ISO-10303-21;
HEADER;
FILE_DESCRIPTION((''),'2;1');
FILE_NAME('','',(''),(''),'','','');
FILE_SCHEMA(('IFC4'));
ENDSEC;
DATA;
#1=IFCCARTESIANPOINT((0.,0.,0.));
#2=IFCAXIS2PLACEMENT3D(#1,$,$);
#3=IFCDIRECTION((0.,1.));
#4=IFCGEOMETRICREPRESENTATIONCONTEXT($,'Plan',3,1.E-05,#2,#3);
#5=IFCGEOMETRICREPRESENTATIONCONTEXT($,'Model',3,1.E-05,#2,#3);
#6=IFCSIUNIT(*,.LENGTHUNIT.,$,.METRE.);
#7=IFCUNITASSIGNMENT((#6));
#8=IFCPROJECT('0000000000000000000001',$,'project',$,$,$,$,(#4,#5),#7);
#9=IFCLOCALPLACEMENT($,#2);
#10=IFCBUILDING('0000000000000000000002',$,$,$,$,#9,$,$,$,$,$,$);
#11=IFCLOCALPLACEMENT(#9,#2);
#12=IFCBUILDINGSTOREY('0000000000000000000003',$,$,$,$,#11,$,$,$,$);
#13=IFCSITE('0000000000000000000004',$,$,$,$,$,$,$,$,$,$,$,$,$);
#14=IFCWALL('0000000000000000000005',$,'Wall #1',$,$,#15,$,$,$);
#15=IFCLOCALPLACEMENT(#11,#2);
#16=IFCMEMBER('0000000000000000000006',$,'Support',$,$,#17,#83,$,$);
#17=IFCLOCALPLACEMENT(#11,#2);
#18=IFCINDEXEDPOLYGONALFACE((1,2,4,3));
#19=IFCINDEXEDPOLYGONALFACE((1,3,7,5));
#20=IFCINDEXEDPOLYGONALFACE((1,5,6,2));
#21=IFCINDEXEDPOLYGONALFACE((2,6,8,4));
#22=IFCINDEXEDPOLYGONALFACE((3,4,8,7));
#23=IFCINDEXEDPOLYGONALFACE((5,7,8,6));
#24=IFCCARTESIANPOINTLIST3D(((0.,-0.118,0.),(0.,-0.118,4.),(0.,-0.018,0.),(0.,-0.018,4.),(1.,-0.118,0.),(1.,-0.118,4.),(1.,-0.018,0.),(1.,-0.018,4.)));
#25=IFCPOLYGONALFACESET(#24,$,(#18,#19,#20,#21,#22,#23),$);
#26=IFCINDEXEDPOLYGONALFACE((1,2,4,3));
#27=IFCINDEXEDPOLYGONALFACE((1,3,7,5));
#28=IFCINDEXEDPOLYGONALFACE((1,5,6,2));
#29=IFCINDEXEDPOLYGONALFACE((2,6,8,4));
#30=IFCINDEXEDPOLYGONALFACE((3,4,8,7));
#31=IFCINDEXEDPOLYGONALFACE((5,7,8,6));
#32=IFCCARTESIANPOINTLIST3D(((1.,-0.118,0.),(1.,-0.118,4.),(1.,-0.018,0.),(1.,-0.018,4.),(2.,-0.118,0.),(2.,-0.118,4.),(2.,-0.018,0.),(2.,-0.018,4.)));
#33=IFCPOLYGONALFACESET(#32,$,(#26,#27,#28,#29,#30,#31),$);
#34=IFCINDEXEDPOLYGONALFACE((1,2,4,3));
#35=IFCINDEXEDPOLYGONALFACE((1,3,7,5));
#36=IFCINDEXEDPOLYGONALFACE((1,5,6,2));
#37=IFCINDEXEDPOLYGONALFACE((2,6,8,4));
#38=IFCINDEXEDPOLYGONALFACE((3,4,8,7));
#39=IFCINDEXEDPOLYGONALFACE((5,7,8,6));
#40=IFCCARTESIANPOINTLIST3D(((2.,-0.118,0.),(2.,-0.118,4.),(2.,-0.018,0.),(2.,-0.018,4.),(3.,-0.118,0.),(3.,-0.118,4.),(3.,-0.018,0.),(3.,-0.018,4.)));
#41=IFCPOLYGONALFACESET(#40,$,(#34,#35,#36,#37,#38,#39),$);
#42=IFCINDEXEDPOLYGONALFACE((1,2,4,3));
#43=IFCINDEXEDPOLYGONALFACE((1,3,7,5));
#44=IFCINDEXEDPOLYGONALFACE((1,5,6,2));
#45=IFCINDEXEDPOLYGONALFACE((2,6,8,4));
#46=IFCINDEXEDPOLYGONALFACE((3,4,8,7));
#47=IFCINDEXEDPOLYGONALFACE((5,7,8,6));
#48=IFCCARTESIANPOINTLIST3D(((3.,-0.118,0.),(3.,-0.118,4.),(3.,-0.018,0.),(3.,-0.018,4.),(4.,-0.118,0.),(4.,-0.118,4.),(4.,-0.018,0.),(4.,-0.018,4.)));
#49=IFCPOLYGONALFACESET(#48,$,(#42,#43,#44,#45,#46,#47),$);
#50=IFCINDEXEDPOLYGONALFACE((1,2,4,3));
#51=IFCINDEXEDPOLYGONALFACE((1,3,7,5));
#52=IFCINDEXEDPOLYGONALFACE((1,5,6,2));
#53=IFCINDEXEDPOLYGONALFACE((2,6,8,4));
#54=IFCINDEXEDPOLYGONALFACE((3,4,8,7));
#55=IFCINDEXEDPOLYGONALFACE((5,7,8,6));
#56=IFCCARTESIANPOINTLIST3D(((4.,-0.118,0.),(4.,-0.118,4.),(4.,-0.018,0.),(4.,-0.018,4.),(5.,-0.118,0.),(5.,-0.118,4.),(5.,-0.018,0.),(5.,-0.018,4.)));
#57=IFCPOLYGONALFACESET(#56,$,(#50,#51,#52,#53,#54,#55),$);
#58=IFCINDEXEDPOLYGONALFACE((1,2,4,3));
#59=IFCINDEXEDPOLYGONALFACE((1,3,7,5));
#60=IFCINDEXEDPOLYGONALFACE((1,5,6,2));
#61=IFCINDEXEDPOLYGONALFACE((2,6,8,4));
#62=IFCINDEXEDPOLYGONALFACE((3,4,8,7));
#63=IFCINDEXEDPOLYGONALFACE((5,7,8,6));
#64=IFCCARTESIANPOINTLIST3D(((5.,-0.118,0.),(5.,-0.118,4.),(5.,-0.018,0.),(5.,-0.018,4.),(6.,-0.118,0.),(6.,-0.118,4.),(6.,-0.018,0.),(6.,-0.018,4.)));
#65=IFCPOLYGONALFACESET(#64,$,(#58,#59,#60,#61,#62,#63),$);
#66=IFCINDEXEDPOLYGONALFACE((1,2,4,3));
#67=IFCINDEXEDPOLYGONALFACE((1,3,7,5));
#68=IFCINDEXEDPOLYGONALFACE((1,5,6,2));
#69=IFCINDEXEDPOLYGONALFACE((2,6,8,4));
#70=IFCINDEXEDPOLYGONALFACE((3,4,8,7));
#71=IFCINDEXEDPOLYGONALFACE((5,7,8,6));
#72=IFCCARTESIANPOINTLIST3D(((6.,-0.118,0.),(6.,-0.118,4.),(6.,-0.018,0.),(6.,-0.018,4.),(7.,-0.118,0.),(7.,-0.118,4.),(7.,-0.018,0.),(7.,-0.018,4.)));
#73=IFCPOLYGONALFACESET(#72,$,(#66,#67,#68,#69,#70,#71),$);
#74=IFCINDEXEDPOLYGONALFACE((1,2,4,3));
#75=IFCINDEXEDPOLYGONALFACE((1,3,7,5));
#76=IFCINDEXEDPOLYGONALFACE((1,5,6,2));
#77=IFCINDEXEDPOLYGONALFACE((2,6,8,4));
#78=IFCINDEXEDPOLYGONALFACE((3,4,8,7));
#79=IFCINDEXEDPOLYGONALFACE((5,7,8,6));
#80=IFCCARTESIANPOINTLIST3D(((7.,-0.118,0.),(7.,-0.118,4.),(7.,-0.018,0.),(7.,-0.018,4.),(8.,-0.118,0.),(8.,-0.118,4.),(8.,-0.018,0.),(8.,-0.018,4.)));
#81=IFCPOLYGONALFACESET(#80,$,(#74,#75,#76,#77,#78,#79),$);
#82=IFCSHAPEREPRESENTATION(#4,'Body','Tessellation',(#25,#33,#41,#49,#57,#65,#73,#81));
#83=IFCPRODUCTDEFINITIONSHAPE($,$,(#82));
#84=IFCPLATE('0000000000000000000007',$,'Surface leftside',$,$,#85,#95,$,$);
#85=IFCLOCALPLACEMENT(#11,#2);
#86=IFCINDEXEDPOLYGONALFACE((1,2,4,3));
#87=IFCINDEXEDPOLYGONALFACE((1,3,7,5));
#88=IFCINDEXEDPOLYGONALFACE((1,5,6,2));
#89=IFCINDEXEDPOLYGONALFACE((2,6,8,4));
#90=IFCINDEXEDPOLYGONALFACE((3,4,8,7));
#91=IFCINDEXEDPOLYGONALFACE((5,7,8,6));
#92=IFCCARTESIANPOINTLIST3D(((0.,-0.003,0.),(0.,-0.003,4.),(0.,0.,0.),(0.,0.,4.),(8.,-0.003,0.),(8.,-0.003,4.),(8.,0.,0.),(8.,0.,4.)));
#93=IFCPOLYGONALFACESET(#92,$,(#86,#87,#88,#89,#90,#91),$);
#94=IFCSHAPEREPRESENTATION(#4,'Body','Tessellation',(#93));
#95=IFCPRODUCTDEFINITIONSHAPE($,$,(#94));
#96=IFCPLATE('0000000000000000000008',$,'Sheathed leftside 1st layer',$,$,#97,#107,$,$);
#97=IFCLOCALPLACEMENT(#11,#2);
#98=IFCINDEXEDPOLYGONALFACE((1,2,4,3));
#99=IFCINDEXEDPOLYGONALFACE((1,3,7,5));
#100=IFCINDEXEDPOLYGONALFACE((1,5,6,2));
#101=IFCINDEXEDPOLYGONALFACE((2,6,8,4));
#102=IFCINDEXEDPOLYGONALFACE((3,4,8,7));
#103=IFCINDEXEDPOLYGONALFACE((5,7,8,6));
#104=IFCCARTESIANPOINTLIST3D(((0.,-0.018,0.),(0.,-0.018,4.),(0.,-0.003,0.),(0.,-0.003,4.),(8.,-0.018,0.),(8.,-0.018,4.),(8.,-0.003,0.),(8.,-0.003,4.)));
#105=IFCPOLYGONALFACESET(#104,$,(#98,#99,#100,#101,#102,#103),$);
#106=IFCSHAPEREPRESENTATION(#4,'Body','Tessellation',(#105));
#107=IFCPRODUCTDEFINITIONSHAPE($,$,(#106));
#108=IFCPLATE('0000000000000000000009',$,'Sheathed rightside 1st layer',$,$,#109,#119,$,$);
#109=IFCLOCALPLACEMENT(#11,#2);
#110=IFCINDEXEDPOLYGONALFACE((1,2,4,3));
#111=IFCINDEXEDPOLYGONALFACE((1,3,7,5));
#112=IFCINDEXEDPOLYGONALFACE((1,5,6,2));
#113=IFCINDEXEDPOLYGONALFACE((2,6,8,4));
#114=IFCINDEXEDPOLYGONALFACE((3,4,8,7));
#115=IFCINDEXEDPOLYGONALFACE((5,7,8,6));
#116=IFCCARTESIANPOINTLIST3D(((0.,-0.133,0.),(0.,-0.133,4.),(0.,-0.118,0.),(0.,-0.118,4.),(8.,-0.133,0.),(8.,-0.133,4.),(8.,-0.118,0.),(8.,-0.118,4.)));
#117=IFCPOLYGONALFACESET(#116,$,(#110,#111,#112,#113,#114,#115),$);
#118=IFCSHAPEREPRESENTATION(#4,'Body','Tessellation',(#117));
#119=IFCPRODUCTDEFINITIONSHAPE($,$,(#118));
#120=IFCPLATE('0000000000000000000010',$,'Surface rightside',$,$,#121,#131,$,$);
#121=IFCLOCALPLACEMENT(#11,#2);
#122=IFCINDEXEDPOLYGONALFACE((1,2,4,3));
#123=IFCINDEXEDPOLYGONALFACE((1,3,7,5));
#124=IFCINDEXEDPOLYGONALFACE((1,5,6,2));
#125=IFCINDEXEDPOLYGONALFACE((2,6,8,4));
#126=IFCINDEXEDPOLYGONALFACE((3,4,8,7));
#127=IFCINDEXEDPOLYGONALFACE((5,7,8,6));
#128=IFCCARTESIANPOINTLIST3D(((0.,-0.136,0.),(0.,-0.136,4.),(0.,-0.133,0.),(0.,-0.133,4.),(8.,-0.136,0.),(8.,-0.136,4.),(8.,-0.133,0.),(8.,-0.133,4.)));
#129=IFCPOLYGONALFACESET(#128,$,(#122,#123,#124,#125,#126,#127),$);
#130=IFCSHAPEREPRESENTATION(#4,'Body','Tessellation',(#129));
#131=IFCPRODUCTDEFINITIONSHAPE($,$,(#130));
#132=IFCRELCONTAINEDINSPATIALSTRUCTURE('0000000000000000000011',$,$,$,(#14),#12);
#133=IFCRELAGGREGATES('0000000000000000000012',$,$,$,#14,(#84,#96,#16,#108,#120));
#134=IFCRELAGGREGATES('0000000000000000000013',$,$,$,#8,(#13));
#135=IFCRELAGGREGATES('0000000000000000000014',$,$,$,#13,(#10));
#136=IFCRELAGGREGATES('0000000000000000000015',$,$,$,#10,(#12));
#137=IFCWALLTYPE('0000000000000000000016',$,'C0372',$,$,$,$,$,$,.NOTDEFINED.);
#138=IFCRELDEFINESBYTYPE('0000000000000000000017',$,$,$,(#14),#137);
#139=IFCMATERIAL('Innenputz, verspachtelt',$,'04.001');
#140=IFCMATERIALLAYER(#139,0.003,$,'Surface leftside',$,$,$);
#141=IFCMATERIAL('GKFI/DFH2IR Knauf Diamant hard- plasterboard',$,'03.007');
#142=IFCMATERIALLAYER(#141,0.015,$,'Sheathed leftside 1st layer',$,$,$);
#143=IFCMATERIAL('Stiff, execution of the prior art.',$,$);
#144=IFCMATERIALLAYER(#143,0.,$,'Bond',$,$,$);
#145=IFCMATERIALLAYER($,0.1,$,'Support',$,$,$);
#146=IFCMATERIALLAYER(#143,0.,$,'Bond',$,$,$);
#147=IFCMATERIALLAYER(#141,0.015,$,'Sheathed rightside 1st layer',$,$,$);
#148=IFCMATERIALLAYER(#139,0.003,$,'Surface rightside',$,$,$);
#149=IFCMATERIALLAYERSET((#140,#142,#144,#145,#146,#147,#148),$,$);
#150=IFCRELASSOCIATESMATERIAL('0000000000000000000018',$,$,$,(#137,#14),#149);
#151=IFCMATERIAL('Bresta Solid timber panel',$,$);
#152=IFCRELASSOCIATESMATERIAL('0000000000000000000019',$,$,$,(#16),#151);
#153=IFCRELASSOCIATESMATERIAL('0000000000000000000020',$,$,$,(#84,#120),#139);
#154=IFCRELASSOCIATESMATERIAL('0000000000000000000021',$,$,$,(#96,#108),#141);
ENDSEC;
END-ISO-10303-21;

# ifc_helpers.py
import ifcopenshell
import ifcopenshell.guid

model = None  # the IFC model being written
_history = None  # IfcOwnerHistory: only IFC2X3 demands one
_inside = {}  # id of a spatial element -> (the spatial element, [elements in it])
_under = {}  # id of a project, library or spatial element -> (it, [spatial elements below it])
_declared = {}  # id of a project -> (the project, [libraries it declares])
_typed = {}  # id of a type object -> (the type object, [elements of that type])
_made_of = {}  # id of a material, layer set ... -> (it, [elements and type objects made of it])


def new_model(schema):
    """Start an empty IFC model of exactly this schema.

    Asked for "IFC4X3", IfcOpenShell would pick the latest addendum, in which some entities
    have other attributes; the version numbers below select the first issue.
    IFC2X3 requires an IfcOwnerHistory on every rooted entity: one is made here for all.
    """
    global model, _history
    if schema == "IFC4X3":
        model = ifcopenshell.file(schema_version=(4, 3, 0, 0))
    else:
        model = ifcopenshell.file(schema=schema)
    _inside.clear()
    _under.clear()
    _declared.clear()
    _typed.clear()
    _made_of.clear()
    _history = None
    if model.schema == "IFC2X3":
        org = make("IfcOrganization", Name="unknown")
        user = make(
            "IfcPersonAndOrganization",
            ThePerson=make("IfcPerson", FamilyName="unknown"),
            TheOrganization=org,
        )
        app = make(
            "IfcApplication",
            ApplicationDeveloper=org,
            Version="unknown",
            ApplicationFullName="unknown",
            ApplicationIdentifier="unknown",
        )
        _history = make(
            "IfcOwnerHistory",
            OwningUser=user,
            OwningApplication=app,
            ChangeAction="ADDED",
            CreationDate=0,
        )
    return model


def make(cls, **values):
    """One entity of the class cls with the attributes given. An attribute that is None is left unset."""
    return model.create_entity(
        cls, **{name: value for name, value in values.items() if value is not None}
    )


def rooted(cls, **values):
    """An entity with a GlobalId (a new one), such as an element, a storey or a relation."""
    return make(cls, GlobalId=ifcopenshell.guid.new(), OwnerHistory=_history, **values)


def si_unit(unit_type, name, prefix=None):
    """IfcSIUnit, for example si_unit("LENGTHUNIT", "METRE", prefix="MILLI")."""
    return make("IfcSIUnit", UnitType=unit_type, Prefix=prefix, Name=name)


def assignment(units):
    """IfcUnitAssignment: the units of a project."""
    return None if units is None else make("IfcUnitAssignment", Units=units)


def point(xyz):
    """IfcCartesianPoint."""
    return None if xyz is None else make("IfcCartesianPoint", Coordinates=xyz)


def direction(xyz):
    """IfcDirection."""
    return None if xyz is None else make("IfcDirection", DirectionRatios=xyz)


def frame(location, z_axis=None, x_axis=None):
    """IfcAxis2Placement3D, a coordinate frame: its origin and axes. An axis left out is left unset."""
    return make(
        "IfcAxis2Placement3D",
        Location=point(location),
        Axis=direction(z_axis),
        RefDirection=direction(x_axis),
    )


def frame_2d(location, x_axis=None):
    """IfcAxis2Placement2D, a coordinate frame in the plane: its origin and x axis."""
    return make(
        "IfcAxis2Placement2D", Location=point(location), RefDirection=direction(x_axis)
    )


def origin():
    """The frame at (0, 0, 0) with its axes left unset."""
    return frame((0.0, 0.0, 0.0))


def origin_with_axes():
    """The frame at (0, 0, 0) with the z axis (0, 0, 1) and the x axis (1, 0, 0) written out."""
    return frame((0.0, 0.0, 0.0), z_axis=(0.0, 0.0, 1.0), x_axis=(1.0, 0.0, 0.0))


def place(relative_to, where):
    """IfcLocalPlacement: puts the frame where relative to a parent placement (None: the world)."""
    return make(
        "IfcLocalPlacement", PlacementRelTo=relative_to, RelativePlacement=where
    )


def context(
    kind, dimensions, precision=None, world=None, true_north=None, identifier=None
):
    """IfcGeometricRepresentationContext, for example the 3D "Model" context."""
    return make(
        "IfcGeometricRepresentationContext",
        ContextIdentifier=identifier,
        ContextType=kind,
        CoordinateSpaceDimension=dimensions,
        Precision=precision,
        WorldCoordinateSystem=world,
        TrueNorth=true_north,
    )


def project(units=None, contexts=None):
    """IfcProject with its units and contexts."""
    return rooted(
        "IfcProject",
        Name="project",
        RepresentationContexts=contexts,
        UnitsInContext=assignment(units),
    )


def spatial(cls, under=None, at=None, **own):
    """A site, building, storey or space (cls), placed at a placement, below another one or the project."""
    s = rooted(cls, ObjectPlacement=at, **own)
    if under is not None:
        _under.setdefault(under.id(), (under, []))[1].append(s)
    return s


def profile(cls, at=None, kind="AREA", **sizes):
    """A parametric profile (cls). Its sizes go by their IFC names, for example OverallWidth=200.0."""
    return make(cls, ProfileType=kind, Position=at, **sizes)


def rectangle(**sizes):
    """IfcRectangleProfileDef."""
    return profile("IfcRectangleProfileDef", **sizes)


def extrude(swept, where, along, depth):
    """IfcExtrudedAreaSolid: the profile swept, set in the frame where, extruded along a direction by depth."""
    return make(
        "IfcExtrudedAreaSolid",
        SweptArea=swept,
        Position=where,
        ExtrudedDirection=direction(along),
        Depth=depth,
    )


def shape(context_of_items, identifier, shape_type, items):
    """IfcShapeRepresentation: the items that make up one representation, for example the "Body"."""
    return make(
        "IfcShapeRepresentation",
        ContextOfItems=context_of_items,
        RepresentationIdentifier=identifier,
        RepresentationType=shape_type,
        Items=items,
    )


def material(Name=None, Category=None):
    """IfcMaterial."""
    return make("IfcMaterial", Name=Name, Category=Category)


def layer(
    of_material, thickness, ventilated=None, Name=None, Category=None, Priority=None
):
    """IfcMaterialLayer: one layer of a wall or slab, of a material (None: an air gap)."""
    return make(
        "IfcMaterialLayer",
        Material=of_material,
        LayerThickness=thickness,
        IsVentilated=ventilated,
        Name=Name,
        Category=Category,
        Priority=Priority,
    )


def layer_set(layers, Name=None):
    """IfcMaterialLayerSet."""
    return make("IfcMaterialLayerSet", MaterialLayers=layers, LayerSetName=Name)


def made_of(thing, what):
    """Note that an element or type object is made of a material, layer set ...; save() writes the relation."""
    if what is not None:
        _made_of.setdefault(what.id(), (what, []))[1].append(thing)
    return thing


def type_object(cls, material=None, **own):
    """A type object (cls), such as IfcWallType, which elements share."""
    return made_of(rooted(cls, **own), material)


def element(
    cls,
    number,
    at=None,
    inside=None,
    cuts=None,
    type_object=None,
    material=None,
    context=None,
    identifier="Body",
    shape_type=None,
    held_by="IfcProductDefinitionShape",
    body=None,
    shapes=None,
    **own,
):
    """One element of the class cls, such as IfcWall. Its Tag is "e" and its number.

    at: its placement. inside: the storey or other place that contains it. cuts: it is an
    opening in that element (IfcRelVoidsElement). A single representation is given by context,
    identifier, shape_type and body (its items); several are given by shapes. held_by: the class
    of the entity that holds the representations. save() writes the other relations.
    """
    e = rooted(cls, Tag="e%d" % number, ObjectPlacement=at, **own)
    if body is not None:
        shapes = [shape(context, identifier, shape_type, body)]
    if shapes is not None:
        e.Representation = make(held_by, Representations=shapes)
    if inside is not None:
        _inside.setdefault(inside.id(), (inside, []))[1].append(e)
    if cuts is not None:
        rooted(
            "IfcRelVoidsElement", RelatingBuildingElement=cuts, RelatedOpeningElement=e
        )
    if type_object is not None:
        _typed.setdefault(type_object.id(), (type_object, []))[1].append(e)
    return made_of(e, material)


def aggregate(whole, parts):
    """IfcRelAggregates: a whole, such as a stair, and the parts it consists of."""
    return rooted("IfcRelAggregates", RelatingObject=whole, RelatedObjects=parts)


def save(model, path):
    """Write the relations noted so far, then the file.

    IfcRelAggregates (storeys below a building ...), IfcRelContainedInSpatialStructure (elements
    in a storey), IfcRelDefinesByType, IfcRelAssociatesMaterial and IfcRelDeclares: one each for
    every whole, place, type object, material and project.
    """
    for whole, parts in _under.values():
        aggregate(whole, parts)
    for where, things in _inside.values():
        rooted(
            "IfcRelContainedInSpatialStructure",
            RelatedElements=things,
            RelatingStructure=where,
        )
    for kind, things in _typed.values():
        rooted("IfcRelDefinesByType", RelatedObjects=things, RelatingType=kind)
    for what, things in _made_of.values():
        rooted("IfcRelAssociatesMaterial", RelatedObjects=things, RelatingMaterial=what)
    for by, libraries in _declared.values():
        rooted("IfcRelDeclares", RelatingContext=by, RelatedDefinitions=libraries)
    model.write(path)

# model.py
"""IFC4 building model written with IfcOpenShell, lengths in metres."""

from ifc_helpers import new_model, si_unit, direction, frame, frame_2d, origin, origin_with_axes, place, context, project, spatial, rectangle, extrude, material, layer, layer_set, type_object, element, aggregate, save


model = new_model("IFC4")

# Units and contexts
plan_context = context("Plan", 3, precision=1e-05, world=origin(), true_north=direction((0.0, 1.0)))
model_context = context("Model", 3, precision=1e-05, world=origin(), true_north=direction((0.0, 1.0)))
ifc_project = project(units=[si_unit("LENGTHUNIT", "METRE")], contexts=[plan_context, model_context])

# Site, building, storey
site = spatial("IfcSite", under=ifc_project)
building_placement = place(None, origin())
building = spatial("IfcBuilding", under=site, at=building_placement)
storey_placement = place(building_placement, origin())
storey = spatial("IfcBuildingStorey", under=building, at=storey_placement)

# Wall, member, plates
ifc_material_1 = material(Name="Innenputz, verspachtelt", Category="04.001")
ifc_layer_1 = layer(ifc_material_1, 0.003, Name="Surface leftside")
ifc_material_2 = material(Name="GKFI/DFH2IR Knauf Diamant hard- plasterboard", Category="03.007")
ifc_layer_2 = layer(ifc_material_2, 0.015, Name="Sheathed leftside 1st layer")
ifc_material_3 = material(Name="Stiff, execution of the prior art.")
ifc_layer_3 = layer(ifc_material_3, 0.0, Name="Bond")
ifc_layer_4 = layer(None, 0.1, Name="Support")
ifc_layer_5 = layer(ifc_material_3, 0.0, Name="Bond")
ifc_layer_6 = layer(ifc_material_2, 0.015, Name="Sheathed rightside 1st layer")
ifc_layer_7 = layer(ifc_material_1, 0.003, Name="Surface rightside")
ifc_layer_set = layer_set([ifc_layer_1, ifc_layer_2, ifc_layer_3, ifc_layer_4, ifc_layer_5, ifc_layer_6, ifc_layer_7])
wall_type = type_object("IfcWallType", Name="C0372", PredefinedType="NOTDEFINED", material=ifc_layer_set)
wall_placement = place(None, frame((0.0, 0.0, 0.0), z_axis=(0.0, -1.0, 0.0), x_axis=(1.0, 0.0, 0.0)))
wall = element("IfcWall", 1, at=wall_placement, inside=storey, type_object=wall_type, material=ifc_layer_set, Name="Wall #1")
ifc_material_4 = material(Name="Bresta Solid timber panel")
member_placement = place(wall_placement, origin())
member = element("IfcMember", 2, at=member_placement, material=ifc_material_4, Name="Support", context=plan_context, shape_type="SweptSolid", body=[
    extrude(rectangle(XDim=1.0, YDim=0.1, at=frame_2d((0.5, 0.05), x_axis=(1.0, 0.0))), frame((0.0, 4.0, 0.018), z_axis=(0.0, -1.0, 0.0), x_axis=(1.0, 0.0, 0.0)), (0.0, 0.0, 1.0), 4.0),
    extrude(rectangle(XDim=1.0, YDim=0.1, at=frame_2d((0.5, 0.05), x_axis=(1.0, 0.0))), frame((1.0, 4.0, 0.018), z_axis=(0.0, -1.0, 0.0), x_axis=(1.0, 0.0, 0.0)), (0.0, 0.0, 1.0), 4.0),
    extrude(rectangle(XDim=1.0, YDim=0.1, at=frame_2d((0.5, 0.05), x_axis=(1.0, 0.0))), frame((2.0, 4.0, 0.018), z_axis=(0.0, -1.0, 0.0), x_axis=(1.0, 0.0, 0.0)), (0.0, 0.0, 1.0), 4.0),
    extrude(rectangle(XDim=1.0, YDim=0.1, at=frame_2d((0.5, 0.05), x_axis=(1.0, 0.0))), frame((3.0, 4.0, 0.018), z_axis=(0.0, -1.0, 0.0), x_axis=(1.0, 0.0, 0.0)), (0.0, 0.0, 1.0), 4.0),
    extrude(rectangle(XDim=1.0, YDim=0.1, at=frame_2d((0.5, 0.05), x_axis=(1.0, 0.0))), frame((4.0, 4.0, 0.018), z_axis=(0.0, -1.0, 0.0), x_axis=(1.0, 0.0, 0.0)), (0.0, 0.0, 1.0), 4.0),
    extrude(rectangle(XDim=1.0, YDim=0.1, at=frame_2d((0.5, 0.05), x_axis=(1.0, 0.0))), frame((5.0, 4.0, 0.018), z_axis=(0.0, -1.0, 0.0), x_axis=(1.0, 0.0, 0.0)), (0.0, 0.0, 1.0), 4.0),
    extrude(rectangle(XDim=1.0, YDim=0.1, at=frame_2d((0.5, 0.05), x_axis=(1.0, 0.0))), frame((6.0, 4.0, 0.018), z_axis=(0.0, -1.0, 0.0), x_axis=(1.0, 0.0, 0.0)), (0.0, 0.0, 1.0), 4.0),
    extrude(rectangle(XDim=1.0, YDim=0.1, at=frame_2d((0.5, 0.05), x_axis=(1.0, 0.0))), frame((7.0, 4.0, 0.018), z_axis=(0.0, -1.0, 0.0), x_axis=(1.0, 0.0, 0.0)), (0.0, 0.0, 1.0), 4.0),
])
plate_1_placement = place(wall_placement, origin())
plate_1 = element("IfcPlate", 3, at=plate_1_placement, material=ifc_material_1, Name="Surface leftside", context=plan_context, shape_type="SweptSolid", body=[
    extrude(rectangle(XDim=8.0, YDim=4.0, at=frame_2d((4.0, 2.0), x_axis=(1.0, 0.0))), origin_with_axes(), (0.0, 0.0, 1.0), 0.003),
])
plate_2_placement = place(wall_placement, origin())
plate_2 = element("IfcPlate", 4, at=plate_2_placement, material=ifc_material_2, Name="Sheathed leftside 1st layer", context=plan_context, shape_type="SweptSolid", body=[
    extrude(rectangle(XDim=8.0, YDim=4.0, at=frame_2d((4.0, 2.0), x_axis=(1.0, 0.0))), frame((0.0, 0.0, 0.003), z_axis=(0.0, 0.0, 1.0), x_axis=(1.0, 0.0, 0.0)), (0.0, 0.0, 1.0), 0.015),
])
plate_3_placement = place(wall_placement, origin())
plate_3 = element("IfcPlate", 5, at=plate_3_placement, material=ifc_material_2, Name="Sheathed rightside 1st layer", context=plan_context, shape_type="SweptSolid", body=[
    extrude(rectangle(XDim=8.0, YDim=4.0, at=frame_2d((4.0, 2.0), x_axis=(1.0, 0.0))), frame((0.0, 0.0, 0.118), z_axis=(0.0, 0.0, 1.0), x_axis=(1.0, 0.0, 0.0)), (0.0, 0.0, 1.0), 0.015),
])
plate_4_placement = place(wall_placement, origin())
plate_4 = element("IfcPlate", 6, at=plate_4_placement, material=ifc_material_1, Name="Surface rightside", context=plan_context, shape_type="SweptSolid", body=[
    extrude(rectangle(XDim=8.0, YDim=4.0, at=frame_2d((4.0, 2.0), x_axis=(1.0, 0.0))), frame((0.0, 0.0, 0.133), z_axis=(0.0, 0.0, 1.0), x_axis=(1.0, 0.0, 0.0)), (0.0, 0.0, 1.0), 0.003),
])
aggregate(wall, [plate_1, plate_2, member, plate_3, plate_4])

save(model, "model.ifc")
